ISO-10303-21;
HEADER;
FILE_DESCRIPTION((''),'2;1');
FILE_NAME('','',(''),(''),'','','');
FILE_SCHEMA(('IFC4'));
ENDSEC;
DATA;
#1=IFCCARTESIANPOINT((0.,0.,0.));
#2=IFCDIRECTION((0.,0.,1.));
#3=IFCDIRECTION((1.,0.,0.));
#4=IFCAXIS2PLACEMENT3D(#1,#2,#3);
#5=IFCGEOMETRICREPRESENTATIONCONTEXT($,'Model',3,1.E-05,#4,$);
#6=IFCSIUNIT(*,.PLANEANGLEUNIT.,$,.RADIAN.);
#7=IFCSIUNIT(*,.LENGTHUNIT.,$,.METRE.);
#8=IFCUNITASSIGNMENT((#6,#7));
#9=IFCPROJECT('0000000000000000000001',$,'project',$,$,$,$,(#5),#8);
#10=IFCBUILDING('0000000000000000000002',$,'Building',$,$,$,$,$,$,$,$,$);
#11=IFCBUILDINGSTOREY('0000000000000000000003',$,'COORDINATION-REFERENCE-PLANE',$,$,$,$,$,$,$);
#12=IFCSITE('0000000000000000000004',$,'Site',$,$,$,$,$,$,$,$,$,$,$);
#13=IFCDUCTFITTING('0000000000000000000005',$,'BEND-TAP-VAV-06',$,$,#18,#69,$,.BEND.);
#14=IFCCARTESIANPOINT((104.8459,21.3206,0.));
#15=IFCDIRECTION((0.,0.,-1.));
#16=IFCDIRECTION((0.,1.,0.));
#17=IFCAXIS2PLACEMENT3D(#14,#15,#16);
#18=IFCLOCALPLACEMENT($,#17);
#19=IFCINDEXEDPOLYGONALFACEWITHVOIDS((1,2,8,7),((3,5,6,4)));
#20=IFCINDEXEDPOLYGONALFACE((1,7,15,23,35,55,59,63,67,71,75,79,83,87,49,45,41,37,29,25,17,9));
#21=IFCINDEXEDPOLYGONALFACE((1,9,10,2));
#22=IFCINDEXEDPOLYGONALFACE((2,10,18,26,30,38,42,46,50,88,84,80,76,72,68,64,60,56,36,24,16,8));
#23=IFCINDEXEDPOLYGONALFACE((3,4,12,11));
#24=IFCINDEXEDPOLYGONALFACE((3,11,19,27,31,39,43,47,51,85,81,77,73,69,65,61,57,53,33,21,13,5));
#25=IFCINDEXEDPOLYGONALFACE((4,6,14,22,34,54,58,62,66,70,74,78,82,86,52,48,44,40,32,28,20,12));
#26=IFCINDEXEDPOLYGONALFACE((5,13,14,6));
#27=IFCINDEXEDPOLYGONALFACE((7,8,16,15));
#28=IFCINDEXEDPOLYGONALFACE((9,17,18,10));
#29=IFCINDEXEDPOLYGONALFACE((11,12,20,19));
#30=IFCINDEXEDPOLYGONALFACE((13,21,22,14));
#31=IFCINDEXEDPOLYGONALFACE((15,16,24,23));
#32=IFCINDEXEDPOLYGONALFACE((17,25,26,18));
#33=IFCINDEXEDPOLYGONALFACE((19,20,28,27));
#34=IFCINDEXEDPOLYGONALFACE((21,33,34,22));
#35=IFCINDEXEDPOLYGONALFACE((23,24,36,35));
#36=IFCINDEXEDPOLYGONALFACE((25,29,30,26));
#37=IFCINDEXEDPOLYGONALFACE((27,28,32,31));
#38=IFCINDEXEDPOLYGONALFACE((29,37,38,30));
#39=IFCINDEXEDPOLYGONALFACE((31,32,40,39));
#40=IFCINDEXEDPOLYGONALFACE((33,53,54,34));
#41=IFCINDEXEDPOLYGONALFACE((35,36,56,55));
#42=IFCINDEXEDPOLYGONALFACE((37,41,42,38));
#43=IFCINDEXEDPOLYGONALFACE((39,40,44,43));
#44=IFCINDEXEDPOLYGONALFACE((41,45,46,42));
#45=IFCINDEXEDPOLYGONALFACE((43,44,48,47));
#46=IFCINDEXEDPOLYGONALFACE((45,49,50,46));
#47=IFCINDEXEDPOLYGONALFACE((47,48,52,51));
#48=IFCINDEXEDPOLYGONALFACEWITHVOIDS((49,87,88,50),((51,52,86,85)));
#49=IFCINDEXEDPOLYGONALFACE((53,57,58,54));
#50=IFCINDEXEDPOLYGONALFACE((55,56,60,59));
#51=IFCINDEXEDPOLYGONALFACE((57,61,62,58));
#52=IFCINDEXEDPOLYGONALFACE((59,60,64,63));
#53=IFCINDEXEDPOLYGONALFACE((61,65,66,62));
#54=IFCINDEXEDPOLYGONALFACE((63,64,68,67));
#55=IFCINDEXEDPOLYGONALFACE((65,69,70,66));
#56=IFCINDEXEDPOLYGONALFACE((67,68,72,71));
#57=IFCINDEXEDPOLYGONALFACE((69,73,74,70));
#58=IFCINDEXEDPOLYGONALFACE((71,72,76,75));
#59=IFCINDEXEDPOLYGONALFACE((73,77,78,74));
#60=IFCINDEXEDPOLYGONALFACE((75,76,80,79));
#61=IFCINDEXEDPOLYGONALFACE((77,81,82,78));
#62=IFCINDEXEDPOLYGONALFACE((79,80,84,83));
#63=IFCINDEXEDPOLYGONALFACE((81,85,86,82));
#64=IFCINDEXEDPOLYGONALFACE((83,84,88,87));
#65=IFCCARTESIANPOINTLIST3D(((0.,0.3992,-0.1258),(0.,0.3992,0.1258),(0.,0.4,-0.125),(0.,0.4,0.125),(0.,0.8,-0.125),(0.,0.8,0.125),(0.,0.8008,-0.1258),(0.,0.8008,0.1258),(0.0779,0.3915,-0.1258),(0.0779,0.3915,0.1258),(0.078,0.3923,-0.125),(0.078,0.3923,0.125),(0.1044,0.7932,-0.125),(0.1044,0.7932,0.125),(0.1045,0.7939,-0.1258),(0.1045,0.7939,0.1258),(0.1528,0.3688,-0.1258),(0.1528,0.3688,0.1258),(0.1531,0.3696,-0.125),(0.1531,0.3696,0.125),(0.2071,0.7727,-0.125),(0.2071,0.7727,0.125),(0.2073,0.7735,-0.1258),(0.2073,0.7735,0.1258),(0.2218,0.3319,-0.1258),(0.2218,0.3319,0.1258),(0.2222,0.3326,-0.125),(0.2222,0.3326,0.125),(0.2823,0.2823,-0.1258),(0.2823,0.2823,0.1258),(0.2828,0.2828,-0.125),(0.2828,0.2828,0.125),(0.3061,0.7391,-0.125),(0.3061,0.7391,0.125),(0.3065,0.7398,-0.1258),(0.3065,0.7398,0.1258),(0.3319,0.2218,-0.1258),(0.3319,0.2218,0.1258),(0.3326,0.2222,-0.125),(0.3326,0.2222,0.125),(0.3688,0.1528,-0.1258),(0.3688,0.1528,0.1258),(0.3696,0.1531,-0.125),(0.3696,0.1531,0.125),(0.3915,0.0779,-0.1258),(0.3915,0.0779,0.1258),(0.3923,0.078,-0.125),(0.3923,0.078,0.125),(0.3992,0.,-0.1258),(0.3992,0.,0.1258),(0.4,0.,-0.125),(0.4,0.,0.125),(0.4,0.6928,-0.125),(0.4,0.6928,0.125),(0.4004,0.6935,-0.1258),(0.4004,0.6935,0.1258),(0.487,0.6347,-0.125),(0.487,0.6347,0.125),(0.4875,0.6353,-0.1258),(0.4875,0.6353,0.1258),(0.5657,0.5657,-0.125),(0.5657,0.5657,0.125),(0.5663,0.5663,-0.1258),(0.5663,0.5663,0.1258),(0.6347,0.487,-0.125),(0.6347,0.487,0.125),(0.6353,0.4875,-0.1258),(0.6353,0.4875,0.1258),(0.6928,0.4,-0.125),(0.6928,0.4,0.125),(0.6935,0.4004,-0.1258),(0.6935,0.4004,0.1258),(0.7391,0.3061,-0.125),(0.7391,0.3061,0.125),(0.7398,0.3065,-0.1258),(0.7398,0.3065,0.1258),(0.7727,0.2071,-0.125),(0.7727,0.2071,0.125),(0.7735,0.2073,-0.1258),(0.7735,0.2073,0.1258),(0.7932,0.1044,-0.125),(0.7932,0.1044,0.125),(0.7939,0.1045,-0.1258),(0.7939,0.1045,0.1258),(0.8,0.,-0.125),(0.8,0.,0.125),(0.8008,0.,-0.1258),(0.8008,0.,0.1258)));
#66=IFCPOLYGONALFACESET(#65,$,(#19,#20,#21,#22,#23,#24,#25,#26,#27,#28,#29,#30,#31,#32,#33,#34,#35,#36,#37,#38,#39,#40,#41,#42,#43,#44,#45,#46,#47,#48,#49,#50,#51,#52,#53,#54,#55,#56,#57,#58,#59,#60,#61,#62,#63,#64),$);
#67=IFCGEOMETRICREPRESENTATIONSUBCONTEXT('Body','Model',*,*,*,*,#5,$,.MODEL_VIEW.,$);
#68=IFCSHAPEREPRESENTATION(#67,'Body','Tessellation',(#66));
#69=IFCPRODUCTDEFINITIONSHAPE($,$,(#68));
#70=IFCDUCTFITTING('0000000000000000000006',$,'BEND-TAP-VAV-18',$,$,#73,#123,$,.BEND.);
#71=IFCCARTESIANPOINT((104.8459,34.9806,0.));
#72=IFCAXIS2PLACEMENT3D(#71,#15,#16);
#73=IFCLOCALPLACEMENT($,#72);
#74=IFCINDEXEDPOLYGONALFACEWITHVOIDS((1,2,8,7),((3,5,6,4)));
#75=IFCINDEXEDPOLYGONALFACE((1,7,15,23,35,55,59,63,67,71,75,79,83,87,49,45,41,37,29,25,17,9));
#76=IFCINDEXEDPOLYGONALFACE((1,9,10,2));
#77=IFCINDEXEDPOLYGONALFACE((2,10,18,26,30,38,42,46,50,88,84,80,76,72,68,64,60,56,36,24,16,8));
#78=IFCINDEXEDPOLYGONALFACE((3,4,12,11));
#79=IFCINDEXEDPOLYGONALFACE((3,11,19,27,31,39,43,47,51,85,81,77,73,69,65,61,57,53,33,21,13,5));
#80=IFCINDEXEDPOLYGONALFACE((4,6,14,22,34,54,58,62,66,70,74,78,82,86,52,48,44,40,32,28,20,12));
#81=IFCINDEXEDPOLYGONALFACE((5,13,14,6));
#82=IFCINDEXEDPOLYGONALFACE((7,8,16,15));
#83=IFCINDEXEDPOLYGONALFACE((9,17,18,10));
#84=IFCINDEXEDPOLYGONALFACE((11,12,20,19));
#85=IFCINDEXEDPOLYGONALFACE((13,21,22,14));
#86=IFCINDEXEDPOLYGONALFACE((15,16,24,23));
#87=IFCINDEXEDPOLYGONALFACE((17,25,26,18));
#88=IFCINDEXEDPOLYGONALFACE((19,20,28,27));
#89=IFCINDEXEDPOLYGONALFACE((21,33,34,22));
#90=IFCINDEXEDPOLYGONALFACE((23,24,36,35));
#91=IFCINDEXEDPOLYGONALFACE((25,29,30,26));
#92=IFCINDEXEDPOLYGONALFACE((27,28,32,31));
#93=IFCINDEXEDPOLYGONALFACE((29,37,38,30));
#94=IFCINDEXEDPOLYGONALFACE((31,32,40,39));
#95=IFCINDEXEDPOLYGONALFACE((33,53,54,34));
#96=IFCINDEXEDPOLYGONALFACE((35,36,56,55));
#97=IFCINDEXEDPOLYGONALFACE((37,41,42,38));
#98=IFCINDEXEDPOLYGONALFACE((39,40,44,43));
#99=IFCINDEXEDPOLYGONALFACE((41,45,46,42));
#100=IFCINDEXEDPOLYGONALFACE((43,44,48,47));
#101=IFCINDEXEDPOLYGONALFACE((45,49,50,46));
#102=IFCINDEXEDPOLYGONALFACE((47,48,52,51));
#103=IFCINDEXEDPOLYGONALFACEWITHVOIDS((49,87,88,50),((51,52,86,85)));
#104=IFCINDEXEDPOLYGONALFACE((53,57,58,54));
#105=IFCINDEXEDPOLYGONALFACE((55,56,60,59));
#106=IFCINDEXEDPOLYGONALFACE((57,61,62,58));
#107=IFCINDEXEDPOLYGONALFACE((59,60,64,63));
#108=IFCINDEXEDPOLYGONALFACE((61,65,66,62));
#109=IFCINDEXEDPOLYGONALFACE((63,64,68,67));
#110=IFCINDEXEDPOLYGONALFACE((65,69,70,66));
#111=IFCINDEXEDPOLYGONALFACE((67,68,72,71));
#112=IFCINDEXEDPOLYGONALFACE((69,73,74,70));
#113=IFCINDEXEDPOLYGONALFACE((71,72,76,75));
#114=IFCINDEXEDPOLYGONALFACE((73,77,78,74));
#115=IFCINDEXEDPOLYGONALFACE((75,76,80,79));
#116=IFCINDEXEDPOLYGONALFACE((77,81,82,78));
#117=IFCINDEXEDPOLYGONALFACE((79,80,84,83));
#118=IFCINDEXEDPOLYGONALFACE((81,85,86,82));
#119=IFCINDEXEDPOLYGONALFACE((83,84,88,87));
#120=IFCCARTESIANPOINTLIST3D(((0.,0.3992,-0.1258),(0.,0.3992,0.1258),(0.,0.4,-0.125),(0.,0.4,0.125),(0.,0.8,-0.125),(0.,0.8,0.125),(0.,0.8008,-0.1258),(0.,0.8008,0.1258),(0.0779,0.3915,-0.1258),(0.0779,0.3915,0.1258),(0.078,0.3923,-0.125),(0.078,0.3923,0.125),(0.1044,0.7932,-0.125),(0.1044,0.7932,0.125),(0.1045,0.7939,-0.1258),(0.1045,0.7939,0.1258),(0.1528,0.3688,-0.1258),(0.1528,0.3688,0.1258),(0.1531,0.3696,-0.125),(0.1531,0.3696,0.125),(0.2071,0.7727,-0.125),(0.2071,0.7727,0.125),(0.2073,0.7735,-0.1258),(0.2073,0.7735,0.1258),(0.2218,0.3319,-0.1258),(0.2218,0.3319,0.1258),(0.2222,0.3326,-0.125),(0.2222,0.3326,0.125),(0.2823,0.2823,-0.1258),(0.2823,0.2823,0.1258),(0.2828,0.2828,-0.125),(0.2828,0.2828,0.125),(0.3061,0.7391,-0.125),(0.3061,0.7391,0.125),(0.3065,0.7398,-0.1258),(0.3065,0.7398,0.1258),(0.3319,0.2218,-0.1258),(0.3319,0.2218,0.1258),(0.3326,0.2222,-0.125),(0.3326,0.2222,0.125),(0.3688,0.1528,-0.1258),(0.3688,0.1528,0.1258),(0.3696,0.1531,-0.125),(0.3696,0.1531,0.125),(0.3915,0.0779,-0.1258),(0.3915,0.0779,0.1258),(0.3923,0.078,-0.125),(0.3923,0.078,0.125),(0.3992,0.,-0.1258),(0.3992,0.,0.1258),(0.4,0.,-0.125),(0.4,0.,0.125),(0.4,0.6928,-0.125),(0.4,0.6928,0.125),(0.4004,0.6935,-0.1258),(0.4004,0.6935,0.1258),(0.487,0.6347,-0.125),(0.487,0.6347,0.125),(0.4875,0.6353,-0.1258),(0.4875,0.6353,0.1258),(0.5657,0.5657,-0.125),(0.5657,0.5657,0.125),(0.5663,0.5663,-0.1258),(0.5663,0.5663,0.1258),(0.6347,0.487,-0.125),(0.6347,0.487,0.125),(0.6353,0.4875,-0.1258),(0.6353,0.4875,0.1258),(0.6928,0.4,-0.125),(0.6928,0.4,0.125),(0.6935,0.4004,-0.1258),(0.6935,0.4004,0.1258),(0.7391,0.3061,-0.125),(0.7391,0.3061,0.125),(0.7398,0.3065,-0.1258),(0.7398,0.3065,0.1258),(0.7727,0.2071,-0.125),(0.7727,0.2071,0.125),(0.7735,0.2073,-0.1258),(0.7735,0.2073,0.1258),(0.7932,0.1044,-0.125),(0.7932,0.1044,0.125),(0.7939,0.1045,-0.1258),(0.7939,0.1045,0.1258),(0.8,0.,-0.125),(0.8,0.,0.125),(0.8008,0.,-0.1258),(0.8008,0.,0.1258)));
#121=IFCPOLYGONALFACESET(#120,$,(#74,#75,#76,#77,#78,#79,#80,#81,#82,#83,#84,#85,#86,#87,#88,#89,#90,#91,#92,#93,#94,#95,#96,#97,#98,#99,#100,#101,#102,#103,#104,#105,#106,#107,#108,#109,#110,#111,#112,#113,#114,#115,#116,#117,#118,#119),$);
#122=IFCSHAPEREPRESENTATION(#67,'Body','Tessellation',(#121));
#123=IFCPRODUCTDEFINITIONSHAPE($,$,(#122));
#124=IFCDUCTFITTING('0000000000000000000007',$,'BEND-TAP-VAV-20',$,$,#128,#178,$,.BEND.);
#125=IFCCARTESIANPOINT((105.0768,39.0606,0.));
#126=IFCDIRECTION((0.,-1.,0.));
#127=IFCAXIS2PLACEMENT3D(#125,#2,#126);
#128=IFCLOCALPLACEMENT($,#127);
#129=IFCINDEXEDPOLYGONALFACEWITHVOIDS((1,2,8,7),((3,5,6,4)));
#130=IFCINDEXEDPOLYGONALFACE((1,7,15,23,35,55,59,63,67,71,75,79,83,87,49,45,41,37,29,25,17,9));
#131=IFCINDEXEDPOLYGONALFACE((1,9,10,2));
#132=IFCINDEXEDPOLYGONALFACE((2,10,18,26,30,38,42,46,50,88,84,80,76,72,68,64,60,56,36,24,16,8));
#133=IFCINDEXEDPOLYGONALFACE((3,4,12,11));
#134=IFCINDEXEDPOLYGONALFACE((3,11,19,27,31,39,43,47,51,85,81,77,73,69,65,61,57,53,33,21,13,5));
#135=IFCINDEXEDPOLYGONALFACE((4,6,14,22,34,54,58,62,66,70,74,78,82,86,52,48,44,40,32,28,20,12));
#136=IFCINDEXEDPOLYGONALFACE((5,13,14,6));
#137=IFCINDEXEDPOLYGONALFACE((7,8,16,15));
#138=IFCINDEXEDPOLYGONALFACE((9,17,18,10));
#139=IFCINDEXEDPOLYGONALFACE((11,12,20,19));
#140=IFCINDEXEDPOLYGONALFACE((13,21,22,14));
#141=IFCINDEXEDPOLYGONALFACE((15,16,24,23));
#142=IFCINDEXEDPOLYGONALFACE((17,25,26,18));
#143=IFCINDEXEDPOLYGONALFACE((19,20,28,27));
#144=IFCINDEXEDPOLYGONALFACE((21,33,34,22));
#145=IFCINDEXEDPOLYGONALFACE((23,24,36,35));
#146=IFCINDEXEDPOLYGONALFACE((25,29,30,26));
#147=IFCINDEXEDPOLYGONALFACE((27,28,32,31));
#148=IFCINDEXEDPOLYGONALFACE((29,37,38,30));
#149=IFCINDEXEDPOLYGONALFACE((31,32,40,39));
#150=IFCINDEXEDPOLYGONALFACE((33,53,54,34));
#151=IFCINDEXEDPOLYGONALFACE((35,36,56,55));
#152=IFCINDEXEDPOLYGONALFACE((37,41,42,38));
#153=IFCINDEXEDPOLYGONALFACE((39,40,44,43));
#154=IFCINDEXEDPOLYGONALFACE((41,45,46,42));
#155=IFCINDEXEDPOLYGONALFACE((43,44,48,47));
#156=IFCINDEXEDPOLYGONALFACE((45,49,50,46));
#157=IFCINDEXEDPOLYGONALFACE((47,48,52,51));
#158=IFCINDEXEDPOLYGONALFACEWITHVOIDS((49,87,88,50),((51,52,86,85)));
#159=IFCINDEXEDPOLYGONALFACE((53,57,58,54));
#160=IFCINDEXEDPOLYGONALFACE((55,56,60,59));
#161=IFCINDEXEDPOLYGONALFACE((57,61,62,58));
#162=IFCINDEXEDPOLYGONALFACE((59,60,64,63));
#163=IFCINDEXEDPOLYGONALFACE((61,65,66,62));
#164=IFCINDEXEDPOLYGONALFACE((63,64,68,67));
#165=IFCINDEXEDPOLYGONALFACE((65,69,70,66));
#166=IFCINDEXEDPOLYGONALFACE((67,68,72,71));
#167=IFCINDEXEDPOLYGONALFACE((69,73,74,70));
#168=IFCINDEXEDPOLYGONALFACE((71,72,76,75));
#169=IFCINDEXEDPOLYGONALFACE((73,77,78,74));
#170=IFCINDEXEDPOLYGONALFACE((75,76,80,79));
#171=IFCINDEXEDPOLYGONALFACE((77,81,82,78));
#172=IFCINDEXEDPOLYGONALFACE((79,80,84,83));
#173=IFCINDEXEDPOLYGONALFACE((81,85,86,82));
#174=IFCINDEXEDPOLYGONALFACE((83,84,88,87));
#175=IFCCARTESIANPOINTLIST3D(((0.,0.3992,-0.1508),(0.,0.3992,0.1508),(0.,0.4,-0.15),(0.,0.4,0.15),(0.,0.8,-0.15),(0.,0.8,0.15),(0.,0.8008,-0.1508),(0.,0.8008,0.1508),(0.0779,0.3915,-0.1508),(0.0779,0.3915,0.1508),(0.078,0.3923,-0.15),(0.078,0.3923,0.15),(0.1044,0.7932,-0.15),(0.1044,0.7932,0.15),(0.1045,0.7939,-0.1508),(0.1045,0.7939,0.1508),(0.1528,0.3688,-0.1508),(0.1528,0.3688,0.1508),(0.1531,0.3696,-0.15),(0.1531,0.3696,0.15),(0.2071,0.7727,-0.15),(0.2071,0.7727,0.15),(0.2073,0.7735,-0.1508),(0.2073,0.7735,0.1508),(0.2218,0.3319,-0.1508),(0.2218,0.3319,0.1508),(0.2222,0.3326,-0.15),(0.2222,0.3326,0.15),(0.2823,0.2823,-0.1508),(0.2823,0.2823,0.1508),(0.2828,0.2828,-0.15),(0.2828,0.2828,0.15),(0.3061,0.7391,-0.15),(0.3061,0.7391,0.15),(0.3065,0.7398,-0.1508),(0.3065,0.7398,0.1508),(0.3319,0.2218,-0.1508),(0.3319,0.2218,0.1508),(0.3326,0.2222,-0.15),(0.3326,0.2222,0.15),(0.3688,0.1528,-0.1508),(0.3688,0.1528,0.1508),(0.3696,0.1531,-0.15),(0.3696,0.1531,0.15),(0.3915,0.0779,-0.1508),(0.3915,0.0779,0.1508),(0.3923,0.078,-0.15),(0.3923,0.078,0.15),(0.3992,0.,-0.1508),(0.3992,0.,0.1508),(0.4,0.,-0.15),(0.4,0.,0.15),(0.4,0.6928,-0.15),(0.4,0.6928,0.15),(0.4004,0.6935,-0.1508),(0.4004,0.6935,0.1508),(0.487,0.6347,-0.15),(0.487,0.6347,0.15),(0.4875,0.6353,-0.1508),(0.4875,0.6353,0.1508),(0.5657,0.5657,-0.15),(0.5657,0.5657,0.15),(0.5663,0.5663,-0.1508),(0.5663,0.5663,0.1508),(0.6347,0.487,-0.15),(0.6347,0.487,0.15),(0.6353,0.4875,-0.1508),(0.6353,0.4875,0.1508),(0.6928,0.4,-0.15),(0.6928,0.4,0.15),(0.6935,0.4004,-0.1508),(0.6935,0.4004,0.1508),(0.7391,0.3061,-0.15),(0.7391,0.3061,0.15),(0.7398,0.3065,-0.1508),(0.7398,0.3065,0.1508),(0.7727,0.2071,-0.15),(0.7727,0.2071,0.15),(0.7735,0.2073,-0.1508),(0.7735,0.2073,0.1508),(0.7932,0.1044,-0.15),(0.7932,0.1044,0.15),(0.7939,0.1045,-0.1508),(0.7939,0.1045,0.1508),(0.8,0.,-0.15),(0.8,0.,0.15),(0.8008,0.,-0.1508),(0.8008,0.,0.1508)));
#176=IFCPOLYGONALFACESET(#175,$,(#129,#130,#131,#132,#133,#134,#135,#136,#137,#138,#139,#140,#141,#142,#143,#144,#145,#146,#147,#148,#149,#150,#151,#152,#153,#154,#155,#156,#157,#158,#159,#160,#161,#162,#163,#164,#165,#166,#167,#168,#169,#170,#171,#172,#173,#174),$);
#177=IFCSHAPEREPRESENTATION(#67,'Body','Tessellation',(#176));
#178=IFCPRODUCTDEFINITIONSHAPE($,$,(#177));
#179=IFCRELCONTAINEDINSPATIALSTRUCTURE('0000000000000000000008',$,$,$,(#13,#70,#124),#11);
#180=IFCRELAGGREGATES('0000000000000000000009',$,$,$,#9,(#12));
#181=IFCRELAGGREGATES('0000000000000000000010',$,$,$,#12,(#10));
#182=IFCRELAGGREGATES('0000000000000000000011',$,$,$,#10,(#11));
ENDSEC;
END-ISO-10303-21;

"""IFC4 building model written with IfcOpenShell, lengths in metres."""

from ifc_helpers import new_model, entity, si_unit, frame, origin_with_axes, place, context, subcontext, project, spatial, element, save


model = new_model("IFC4")

# Units and contexts
model_context = context("Model", 3, precision=1e-05, world=origin_with_axes())
body_context = subcontext(model_context, "Body", "Model", "MODEL_VIEW")
ifc_project = project(units=[si_unit("PLANEANGLEUNIT", "RADIAN"), si_unit("LENGTHUNIT", "METRE")], contexts=[model_context])

# Site, building, storey
site = spatial("IfcSite", under=ifc_project, Name="Site")
building = spatial("IfcBuilding", under=site, Name="Building")
storey = spatial("IfcBuildingStorey", under=building, Name="COORDINATION-REFERENCE-PLANE")

# Duct fittings
duct_fitting_1_placement = place(None, frame((104.8459, 21.3206, 0.0), z_axis=(0.0, 0.0, -1.0), x_axis=(0.0, 1.0, 0.0)))
cartesian_point_1 = entity("IfcCartesianPoint", [0.0, 0.0, 0.0])
element("IfcDuctFitting", 1, at=duct_fitting_1_placement, inside=storey, Name="BEND-TAP-VAV-06", PredefinedType="BEND", context=body_context, shape_type="SweptSolid", body=[
    entity("IfcRevolvedAreaSolid", entity("IfcRectangleHollowProfileDef", "AREA", None, entity("IfcAxis2Placement2D", entity("IfcCartesianPoint", [0.6, 0.0])), 0.4016, 0.2516, 0.0008), entity("IfcAxis2Placement3D", cartesian_point_1, entity("IfcDirection", [0.0, -1.0, 0.0]), entity("IfcDirection", [1.0, 0.0, 0.0])), entity("IfcAxis1Placement", cartesian_point_1, entity("IfcDirection", [0.0, 1.0, 0.0])), 1.570796),
])
duct_fitting_2_placement = place(None, frame((104.8459, 34.9806, 0.0), z_axis=(0.0, 0.0, -1.0), x_axis=(0.0, 1.0, 0.0)))
cartesian_point_2 = entity("IfcCartesianPoint", [0.0, 0.0, 0.0])
element("IfcDuctFitting", 2, at=duct_fitting_2_placement, inside=storey, Name="BEND-TAP-VAV-18", PredefinedType="BEND", context=body_context, shape_type="SweptSolid", body=[
    entity("IfcRevolvedAreaSolid", entity("IfcRectangleHollowProfileDef", "AREA", None, entity("IfcAxis2Placement2D", entity("IfcCartesianPoint", [0.6, 0.0])), 0.4016, 0.2516, 0.0008), entity("IfcAxis2Placement3D", cartesian_point_2, entity("IfcDirection", [0.0, -1.0, 0.0]), entity("IfcDirection", [1.0, 0.0, 0.0])), entity("IfcAxis1Placement", cartesian_point_2, entity("IfcDirection", [0.0, 1.0, 0.0])), 1.570796),
])
duct_fitting_3_placement = place(None, frame((105.0768, 39.0606, 0.0), z_axis=(0.0, 0.0, 1.0), x_axis=(0.0, -1.0, 0.0)))
cartesian_point_3 = entity("IfcCartesianPoint", [0.0, 0.0, 0.0])
element("IfcDuctFitting", 3, at=duct_fitting_3_placement, inside=storey, Name="BEND-TAP-VAV-20", PredefinedType="BEND", context=body_context, shape_type="SweptSolid", body=[
    entity("IfcRevolvedAreaSolid", entity("IfcRectangleHollowProfileDef", "AREA", None, entity("IfcAxis2Placement2D", entity("IfcCartesianPoint", [0.6, 0.0])), 0.4016, 0.3016, 0.0008), entity("IfcAxis2Placement3D", cartesian_point_3, entity("IfcDirection", [0.0, -1.0, 0.0]), entity("IfcDirection", [1.0, 0.0, 0.0])), entity("IfcAxis1Placement", cartesian_point_3, entity("IfcDirection", [0.0, 1.0, 0.0])), 1.570796),
])

save(model, "model.ifc")
